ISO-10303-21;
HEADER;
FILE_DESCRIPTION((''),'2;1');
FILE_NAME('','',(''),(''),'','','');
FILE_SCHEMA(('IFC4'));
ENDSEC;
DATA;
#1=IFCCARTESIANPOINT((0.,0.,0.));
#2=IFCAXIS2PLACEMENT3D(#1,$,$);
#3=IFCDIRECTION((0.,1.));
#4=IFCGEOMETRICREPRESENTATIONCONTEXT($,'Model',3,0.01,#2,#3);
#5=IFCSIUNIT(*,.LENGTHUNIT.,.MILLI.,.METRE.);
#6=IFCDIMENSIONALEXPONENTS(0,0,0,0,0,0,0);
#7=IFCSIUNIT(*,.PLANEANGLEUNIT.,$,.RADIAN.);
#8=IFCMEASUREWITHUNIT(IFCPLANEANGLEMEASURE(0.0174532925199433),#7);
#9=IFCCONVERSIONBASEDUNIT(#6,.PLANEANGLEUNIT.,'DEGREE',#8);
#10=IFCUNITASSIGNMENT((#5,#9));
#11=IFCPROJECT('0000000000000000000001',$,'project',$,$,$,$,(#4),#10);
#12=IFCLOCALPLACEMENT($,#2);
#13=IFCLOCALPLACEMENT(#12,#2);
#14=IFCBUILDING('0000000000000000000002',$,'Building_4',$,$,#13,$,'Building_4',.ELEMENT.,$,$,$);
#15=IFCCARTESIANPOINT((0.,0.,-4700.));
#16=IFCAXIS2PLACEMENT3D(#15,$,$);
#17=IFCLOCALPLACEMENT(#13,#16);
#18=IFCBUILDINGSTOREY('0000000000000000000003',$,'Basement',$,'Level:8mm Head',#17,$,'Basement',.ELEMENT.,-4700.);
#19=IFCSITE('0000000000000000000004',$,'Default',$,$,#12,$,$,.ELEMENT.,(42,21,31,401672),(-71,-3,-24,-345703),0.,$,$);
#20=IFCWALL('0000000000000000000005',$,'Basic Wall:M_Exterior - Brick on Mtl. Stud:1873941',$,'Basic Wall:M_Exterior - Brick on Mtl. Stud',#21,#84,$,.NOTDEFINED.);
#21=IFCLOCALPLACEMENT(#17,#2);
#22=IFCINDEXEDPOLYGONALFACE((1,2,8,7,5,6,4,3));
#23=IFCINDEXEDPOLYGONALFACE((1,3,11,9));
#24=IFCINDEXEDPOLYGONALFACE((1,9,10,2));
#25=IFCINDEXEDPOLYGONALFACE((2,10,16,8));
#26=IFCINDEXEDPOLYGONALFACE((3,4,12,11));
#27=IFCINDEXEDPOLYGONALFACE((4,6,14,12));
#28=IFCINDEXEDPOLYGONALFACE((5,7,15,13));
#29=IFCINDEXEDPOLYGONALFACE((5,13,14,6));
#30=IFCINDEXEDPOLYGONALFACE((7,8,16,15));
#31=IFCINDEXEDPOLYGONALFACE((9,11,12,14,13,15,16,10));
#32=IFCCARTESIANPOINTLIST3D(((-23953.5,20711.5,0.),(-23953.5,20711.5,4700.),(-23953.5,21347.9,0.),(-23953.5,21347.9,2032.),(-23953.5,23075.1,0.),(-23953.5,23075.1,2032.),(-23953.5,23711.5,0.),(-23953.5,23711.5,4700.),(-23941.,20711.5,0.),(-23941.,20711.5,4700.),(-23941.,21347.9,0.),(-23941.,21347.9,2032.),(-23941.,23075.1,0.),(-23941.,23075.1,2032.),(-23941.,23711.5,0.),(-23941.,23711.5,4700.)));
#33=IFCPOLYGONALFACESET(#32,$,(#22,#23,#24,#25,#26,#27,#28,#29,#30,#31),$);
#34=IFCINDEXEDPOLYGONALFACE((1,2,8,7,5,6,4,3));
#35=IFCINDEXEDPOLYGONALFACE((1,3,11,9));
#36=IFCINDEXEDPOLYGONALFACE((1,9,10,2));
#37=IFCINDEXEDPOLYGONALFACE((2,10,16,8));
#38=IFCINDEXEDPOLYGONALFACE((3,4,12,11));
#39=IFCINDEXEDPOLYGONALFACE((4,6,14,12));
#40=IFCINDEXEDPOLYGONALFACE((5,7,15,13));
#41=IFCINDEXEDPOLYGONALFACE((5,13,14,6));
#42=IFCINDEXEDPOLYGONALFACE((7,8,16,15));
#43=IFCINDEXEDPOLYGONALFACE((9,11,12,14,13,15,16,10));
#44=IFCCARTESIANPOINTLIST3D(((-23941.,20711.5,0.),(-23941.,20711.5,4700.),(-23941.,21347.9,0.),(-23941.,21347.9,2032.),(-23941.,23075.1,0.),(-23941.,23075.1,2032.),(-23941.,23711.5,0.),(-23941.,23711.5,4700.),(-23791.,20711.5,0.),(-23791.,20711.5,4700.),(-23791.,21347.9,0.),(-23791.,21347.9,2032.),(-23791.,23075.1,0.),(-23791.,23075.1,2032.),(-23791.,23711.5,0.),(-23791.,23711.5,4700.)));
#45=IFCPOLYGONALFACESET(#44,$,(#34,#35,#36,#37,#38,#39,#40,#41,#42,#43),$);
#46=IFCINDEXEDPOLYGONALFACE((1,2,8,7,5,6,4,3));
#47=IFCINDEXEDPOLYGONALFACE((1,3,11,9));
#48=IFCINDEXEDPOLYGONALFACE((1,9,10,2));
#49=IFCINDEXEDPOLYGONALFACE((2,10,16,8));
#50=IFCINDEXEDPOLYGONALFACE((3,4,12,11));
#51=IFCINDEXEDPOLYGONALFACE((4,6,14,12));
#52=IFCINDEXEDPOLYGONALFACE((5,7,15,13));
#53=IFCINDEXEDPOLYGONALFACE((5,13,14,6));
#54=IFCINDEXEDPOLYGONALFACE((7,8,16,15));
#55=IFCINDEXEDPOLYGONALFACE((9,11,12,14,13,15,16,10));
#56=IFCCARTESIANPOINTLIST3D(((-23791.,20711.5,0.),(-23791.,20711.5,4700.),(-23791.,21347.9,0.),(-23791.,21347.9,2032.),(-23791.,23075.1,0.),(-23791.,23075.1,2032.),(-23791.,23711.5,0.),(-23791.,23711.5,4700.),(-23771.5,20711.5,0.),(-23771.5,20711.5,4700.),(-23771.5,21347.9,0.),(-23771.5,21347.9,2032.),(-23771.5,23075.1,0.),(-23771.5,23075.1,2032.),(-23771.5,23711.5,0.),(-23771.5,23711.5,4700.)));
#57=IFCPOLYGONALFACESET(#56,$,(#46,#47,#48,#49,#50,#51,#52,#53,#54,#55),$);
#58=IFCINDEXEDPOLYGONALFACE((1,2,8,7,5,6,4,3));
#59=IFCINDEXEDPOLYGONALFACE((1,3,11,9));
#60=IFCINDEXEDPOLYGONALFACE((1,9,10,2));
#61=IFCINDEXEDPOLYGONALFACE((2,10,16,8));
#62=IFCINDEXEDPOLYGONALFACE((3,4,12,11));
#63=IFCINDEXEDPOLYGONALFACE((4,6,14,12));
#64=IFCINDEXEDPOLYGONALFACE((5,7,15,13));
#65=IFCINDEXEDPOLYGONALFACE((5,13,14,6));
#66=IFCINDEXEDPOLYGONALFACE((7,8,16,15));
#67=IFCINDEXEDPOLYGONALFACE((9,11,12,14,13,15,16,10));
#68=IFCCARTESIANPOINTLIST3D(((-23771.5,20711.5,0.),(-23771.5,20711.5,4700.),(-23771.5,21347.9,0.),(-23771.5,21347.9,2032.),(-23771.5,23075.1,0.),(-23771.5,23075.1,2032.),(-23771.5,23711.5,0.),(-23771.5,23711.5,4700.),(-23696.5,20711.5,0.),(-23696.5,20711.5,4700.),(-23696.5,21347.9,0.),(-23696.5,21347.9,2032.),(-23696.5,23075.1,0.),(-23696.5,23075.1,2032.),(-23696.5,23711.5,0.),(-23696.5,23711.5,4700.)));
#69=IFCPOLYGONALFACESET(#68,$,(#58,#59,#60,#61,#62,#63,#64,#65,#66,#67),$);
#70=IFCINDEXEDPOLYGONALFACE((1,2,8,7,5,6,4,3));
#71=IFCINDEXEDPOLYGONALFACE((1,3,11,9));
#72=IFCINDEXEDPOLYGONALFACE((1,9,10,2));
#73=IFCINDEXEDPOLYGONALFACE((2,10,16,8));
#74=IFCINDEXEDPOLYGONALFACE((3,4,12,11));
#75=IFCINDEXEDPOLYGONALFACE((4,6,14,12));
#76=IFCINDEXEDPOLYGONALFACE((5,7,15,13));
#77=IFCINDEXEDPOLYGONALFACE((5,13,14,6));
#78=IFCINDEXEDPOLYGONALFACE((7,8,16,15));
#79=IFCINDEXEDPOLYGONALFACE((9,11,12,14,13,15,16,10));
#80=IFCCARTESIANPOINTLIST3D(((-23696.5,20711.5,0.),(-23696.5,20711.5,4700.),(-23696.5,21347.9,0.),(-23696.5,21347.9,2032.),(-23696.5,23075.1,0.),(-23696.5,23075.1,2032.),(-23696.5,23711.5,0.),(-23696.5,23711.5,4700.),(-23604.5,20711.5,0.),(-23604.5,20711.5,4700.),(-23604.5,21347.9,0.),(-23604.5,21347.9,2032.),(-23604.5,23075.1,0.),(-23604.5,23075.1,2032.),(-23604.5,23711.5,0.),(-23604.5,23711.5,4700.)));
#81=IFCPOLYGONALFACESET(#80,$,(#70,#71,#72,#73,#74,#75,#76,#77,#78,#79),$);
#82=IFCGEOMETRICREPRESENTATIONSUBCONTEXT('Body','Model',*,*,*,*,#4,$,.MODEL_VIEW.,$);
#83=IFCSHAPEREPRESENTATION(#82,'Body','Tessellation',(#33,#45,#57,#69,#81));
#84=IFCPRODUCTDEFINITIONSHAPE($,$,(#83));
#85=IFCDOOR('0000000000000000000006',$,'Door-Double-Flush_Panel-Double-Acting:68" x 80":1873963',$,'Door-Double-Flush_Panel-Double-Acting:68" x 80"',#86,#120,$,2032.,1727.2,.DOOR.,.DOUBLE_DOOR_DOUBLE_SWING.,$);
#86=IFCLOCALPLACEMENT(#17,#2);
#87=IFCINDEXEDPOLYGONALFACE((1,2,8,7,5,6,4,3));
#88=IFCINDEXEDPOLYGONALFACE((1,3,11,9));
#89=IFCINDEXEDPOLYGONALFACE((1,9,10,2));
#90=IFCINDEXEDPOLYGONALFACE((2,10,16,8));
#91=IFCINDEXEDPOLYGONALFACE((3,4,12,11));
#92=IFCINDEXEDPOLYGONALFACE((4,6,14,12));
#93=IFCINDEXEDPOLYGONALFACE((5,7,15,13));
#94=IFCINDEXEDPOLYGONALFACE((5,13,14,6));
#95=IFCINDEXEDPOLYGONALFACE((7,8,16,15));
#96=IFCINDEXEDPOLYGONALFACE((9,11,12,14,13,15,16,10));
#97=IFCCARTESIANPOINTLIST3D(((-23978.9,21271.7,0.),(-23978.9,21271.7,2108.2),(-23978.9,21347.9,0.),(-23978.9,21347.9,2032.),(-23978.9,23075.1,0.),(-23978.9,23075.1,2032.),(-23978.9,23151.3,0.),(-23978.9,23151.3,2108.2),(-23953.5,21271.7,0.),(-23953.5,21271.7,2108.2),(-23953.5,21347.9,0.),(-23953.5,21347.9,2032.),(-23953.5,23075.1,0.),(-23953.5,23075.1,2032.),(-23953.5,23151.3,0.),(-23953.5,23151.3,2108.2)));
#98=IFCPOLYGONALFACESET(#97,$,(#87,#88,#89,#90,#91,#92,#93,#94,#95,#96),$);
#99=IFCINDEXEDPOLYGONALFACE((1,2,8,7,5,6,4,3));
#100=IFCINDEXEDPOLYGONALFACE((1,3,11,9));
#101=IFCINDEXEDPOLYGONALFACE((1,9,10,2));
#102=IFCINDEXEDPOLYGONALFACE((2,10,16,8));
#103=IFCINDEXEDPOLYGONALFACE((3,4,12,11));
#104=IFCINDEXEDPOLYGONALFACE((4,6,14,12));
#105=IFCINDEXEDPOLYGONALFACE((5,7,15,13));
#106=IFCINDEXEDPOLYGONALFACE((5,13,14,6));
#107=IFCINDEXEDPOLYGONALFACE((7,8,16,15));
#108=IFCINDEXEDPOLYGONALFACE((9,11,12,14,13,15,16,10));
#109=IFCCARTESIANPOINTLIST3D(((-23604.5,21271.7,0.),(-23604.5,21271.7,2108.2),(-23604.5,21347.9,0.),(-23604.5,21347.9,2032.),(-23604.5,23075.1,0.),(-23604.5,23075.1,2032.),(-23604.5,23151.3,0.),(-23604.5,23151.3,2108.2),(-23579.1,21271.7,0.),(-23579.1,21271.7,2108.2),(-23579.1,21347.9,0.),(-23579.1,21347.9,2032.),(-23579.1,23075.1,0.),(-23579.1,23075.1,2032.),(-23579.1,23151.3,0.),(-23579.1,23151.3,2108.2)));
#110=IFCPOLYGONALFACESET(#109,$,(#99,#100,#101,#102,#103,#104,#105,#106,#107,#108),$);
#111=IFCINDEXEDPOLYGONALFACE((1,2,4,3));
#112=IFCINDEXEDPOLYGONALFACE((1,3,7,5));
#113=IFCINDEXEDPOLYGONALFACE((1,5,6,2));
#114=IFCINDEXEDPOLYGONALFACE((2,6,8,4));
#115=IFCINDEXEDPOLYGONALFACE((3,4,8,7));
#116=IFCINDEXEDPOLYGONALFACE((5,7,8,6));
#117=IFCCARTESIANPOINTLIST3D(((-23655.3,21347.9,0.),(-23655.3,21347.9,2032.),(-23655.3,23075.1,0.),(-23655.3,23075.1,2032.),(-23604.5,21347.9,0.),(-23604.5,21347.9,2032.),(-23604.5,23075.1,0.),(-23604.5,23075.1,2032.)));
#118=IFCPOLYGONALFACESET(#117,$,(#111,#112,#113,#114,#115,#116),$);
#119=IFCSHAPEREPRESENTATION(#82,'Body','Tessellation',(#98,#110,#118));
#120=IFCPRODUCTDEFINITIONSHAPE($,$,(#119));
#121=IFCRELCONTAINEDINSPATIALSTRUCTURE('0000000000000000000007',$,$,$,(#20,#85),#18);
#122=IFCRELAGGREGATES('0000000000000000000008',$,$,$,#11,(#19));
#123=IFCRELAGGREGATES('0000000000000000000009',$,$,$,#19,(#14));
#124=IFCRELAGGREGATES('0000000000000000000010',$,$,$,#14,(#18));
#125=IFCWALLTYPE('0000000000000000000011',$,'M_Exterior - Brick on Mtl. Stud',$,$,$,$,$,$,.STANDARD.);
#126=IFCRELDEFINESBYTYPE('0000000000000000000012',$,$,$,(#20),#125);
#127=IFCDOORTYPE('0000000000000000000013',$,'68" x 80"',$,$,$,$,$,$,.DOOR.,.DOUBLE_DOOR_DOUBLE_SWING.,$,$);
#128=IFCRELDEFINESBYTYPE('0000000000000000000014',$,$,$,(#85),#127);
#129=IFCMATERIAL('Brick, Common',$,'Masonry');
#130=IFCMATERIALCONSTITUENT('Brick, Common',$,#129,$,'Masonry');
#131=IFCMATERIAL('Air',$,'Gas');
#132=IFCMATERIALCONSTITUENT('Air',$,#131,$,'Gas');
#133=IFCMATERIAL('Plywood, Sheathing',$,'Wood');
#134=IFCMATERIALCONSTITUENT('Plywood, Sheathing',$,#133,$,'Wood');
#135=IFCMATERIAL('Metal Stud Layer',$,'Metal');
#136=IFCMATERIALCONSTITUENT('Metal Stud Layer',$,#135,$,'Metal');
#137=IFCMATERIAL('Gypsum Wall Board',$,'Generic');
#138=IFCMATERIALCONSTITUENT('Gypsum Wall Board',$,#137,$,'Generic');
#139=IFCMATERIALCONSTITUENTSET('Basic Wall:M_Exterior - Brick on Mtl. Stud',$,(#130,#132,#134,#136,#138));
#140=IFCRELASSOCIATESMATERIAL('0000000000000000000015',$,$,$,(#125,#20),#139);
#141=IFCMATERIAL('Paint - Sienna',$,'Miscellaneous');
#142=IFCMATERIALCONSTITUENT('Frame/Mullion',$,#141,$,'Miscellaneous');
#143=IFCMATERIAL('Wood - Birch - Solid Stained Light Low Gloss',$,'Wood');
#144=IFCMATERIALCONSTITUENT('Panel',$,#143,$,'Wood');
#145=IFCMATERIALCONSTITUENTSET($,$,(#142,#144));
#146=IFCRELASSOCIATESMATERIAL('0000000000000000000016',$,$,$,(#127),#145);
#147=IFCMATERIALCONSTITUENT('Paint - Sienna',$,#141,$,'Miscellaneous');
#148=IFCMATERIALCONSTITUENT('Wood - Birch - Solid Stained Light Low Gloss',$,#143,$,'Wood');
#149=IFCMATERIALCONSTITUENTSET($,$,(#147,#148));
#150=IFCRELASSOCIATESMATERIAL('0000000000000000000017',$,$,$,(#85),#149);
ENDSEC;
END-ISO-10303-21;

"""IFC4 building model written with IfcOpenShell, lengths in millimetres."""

from ifc_helpers import new_model, entity, si_unit, converted_unit, direction, frame, origin, place, context, subcontext, project, spatial, indexed_curve, outline, extrude, source, transform, mapped, material, constituent, constituent_set, type_object, type_shapes, element, fill, save


model = new_model("IFC4")

# Units and contexts
model_context = context("Model", 3, precision=0.01, world=origin(), true_north=direction((0.0, 1.0)))
body_context = subcontext(model_context, "Body", "Model", "MODEL_VIEW")
ifc_project = project(units=[si_unit("LENGTHUNIT", "METRE", prefix="MILLI"), converted_unit("PLANEANGLEUNIT", "DEGREE", entity("IfcPlaneAngleMeasure", 0.0174532925199433), si_unit("PLANEANGLEUNIT", "RADIAN"), dimensions=[0, 0, 0, 0, 0, 0, 0])], contexts=[model_context])

# Site, building, storey
site_placement = place(None, origin())
site = spatial("IfcSite", under=ifc_project, at=site_placement, Name="Default", CompositionType="ELEMENT", RefLatitude=(42, 21, 31, 401672), RefLongitude=(-71, -3, -24, -345703), RefElevation=0.0)
building_placement = place(site_placement, origin())
building = spatial("IfcBuilding", under=site, at=building_placement, Name="Building_4", LongName="Building_4", CompositionType="ELEMENT")
storey_placement = place(building_placement, frame((0.0, 0.0, -4700.0)))
storey = spatial("IfcBuildingStorey", under=building, at=storey_placement, Name="Basement", ObjectType="Level:8mm Head", LongName="Basement", CompositionType="ELEMENT", Elevation=-4700.0)

# Shared definitions
ifc_material_1 = material(Name="Brick, Common", Category="Masonry")
ifc_constituent_1 = constituent(ifc_material_1, Name="Brick, Common", Category="Masonry")
ifc_material_2 = material(Name="Air", Category="Gas")
ifc_constituent_2 = constituent(ifc_material_2, Name="Air", Category="Gas")
ifc_material_3 = material(Name="Plywood, Sheathing", Category="Wood")
ifc_constituent_3 = constituent(ifc_material_3, Name="Plywood, Sheathing", Category="Wood")
ifc_material_4 = material(Name="Metal Stud Layer", Category="Metal")
ifc_constituent_4 = constituent(ifc_material_4, Name="Metal Stud Layer", Category="Metal")
ifc_material_5 = material(Name="Gypsum Wall Board", Category="Generic")
ifc_constituent_5 = constituent(ifc_material_5, Name="Gypsum Wall Board", Category="Generic")
ifc_constituent_set_1 = constituent_set(constituents=[ifc_constituent_1, ifc_constituent_2, ifc_constituent_3, ifc_constituent_4, ifc_constituent_5], Name="Basic Wall:M_Exterior - Brick on Mtl. Stud")
wall_type_1 = type_object("IfcWallType", Name="M_Exterior - Brick on Mtl. Stud", PredefinedType="STANDARD", material=ifc_constituent_set_1)

# Wall, opening, door
wall_1_placement = place(storey_placement, frame((-23779.0, 23711.5, 0.0), z_axis=(0.0, 0.0, 1.0), x_axis=(0.0, -1.0, 0.0)))
wall_1 = element("IfcWall", 1, at=wall_1_placement, inside=storey, type_object=wall_type_1, material=ifc_constituent_set_1, Name="Basic Wall:M_Exterior - Brick on Mtl. Stud:1873941", ObjectType="Basic Wall:M_Exterior - Brick on Mtl. Stud", PredefinedType="NOTDEFINED", context=body_context, shape_type="SweptSolid", body=[
    extrude(outline(indexed_curve([(-1500.0, -1683.0), (-863.6, -1683.0), (-863.6, 349.0), (863.6, 349.0), (863.6, -1683.0), (1500.0, -1683.0), (1500.0, 3017.0), (-1500.0, 3017.0), (-1500.0, -1683.0)], self_intersect=False)), frame((1500.0, -174.5, 1683.0), z_axis=(0.0, 1.0, 0.0), x_axis=(-1.0, 0.0, 0.0)), (0.0, 0.0, 1.0), 12.5),
    extrude(outline(indexed_curve([(-1683.0, -863.6), (-1683.0, -1500.0), (3017.0, -1500.0), (3017.0, 1500.0), (-1683.0, 1500.0), (-1683.0, 863.6), (349.0, 863.6), (349.0, -863.6), (-1683.0, -863.6)], self_intersect=False)), frame((1500.0, -162.0, 1683.0), z_axis=(0.0, -1.0, 0.0), x_axis=(0.0, 0.0, 1.0)), (0.0, 0.0, -1.0), 150.0),
    extrude(outline(indexed_curve([(-1683.0, -863.6), (-1683.0, -1500.0), (3017.0, -1500.0), (3017.0, 1500.0), (-1683.0, 1500.0), (-1683.0, 863.6), (349.0, 863.6), (349.0, -863.6), (-1683.0, -863.6)], self_intersect=False)), frame((1500.0, -12.0, 1683.0), z_axis=(0.0, -1.0, 0.0), x_axis=(0.0, 0.0, 1.0)), (0.0, 0.0, -1.0), 19.5),
    extrude(outline(indexed_curve([(-1683.0, -863.6), (-1683.0, -1500.0), (3017.0, -1500.0), (3017.0, 1500.0), (-1683.0, 1500.0), (-1683.0, 863.6), (349.0, 863.6), (349.0, -863.6), (-1683.0, -863.6)], self_intersect=False)), frame((1500.0, 7.5, 1683.0), z_axis=(0.0, -1.0, 0.0), x_axis=(0.0, 0.0, 1.0)), (0.0, 0.0, -1.0), 75.0),
    extrude(outline(indexed_curve([(-1683.0, -863.6), (-1683.0, -1500.0), (3017.0, -1500.0), (3017.0, 1500.0), (-1683.0, 1500.0), (-1683.0, 863.6), (349.0, 863.6), (349.0, -863.6), (-1683.0, -863.6)], self_intersect=False)), frame((1500.0, 82.5, 1683.0), z_axis=(0.0, -1.0, 0.0), x_axis=(0.0, 0.0, 1.0)), (0.0, 0.0, -1.0), 92.0),
])
opening_1_placement = place(wall_1_placement, frame((636.4, -174.5, 0.0)))
opening_1 = element("IfcOpeningElement", 2, at=opening_1_placement, cuts=wall_1, PredefinedType="OPENING", context=body_context, shape_type="SweptSolid", body=[
    extrude(outline(indexed_curve([(0.0, 1727.2), (0.0, 0.0), (2032.0, 0.0), (2032.0, 1727.2), (0.0, 1727.2)], self_intersect=False)), frame((0.0, 0.0, 0.0), z_axis=(0.0, 1.0, 0.0), x_axis=(0.0, 0.0, 1.0)), (0.0, 0.0, 1.0), 349.0),
])
ifc_material_6 = material(Name="Paint - Sienna", Category="Miscellaneous")
ifc_constituent_6 = constituent(ifc_material_6, Name="Paint - Sienna", Category="Miscellaneous")
ifc_material_7 = material(Name="Wood - Birch - Solid Stained Light Low Gloss", Category="Wood")
ifc_constituent_7 = constituent(ifc_material_7, Name="Wood - Birch - Solid Stained Light Low Gloss", Category="Wood")
ifc_constituent_set_2 = constituent_set(constituents=[ifc_constituent_6, ifc_constituent_7])
ifc_constituent_8 = constituent(ifc_material_6, Name="Frame/Mullion", Category="Miscellaneous")
ifc_constituent_9 = constituent(ifc_material_7, Name="Panel", Category="Wood")
ifc_constituent_set_3 = constituent_set(constituents=[ifc_constituent_8, ifc_constituent_9])
door_type = type_object("IfcDoorType", Name="68\" x 80\"", OperationType="DOUBLE_DOOR_DOUBLE_SWING", PredefinedType="DOOR", material=ifc_constituent_set_3)
shared_shape_1 = source(origin(), body_context, "Body", "SweptSolid", [
    extrude(outline(indexed_curve([(-997.0, 863.6), (1035.0, 863.6), (1035.0, 939.8), (-1073.2, 939.8), (-1073.2, -939.8), (1035.0, -939.8), (1035.0, -863.6), (-997.0, -863.6), (-997.0, 863.6)], self_intersect=False)), frame((863.6, -25.4, 1035.0), z_axis=(0.0, 1.0, 0.0), x_axis=(0.0, 0.0, -1.0)), (0.0, 0.0, 1.0), 25.4),
    extrude(outline(indexed_curve([(-939.8, -1073.2), (939.8, -1073.2), (939.8, 1035.0), (863.6, 1035.0), (863.6, -997.0), (-863.6, -997.0), (-863.6, 1035.0), (-939.8, 1035.0), (-939.8, -1073.2)], self_intersect=False)), frame((863.6, 349.0, 1035.0), z_axis=(0.0, 1.0, 0.0), x_axis=(1.0, 0.0, 0.0)), (0.0, 0.0, 1.0), 25.4),
    extrude(outline(indexed_curve([(-25.4, -863.6), (25.4, -863.6), (25.4, 863.6), (-25.4, 863.6), (-25.4, -863.6)], self_intersect=False)), frame((863.6, 323.6, 0.0), z_axis=(0.0, 0.0, 1.0), x_axis=(0.0, -1.0, 0.0)), (0.0, 0.0, 1.0), 2032.0),
])
type_shapes(door_type, [shared_shape_1])
door_placement = place(opening_1_placement, origin())
door = element("IfcDoor", 3, at=door_placement, inside=storey, type_object=door_type, material=ifc_constituent_set_2, Name="Door-Double-Flush_Panel-Double-Acting:68\" x 80\":1873963", ObjectType="Door-Double-Flush_Panel-Double-Acting:68\" x 80\"", OperationType="DOUBLE_DOOR_DOUBLE_SWING", OverallHeight=2032.0, OverallWidth=1727.2, PredefinedType="DOOR", context=body_context, shape_type="MappedRepresentation", body=[
    mapped(shared_shape_1, transform((0.0, 0.0, 0.0), scale=1.0)),
])
fill(opening_1, door)

save(model, "model.ifc")
